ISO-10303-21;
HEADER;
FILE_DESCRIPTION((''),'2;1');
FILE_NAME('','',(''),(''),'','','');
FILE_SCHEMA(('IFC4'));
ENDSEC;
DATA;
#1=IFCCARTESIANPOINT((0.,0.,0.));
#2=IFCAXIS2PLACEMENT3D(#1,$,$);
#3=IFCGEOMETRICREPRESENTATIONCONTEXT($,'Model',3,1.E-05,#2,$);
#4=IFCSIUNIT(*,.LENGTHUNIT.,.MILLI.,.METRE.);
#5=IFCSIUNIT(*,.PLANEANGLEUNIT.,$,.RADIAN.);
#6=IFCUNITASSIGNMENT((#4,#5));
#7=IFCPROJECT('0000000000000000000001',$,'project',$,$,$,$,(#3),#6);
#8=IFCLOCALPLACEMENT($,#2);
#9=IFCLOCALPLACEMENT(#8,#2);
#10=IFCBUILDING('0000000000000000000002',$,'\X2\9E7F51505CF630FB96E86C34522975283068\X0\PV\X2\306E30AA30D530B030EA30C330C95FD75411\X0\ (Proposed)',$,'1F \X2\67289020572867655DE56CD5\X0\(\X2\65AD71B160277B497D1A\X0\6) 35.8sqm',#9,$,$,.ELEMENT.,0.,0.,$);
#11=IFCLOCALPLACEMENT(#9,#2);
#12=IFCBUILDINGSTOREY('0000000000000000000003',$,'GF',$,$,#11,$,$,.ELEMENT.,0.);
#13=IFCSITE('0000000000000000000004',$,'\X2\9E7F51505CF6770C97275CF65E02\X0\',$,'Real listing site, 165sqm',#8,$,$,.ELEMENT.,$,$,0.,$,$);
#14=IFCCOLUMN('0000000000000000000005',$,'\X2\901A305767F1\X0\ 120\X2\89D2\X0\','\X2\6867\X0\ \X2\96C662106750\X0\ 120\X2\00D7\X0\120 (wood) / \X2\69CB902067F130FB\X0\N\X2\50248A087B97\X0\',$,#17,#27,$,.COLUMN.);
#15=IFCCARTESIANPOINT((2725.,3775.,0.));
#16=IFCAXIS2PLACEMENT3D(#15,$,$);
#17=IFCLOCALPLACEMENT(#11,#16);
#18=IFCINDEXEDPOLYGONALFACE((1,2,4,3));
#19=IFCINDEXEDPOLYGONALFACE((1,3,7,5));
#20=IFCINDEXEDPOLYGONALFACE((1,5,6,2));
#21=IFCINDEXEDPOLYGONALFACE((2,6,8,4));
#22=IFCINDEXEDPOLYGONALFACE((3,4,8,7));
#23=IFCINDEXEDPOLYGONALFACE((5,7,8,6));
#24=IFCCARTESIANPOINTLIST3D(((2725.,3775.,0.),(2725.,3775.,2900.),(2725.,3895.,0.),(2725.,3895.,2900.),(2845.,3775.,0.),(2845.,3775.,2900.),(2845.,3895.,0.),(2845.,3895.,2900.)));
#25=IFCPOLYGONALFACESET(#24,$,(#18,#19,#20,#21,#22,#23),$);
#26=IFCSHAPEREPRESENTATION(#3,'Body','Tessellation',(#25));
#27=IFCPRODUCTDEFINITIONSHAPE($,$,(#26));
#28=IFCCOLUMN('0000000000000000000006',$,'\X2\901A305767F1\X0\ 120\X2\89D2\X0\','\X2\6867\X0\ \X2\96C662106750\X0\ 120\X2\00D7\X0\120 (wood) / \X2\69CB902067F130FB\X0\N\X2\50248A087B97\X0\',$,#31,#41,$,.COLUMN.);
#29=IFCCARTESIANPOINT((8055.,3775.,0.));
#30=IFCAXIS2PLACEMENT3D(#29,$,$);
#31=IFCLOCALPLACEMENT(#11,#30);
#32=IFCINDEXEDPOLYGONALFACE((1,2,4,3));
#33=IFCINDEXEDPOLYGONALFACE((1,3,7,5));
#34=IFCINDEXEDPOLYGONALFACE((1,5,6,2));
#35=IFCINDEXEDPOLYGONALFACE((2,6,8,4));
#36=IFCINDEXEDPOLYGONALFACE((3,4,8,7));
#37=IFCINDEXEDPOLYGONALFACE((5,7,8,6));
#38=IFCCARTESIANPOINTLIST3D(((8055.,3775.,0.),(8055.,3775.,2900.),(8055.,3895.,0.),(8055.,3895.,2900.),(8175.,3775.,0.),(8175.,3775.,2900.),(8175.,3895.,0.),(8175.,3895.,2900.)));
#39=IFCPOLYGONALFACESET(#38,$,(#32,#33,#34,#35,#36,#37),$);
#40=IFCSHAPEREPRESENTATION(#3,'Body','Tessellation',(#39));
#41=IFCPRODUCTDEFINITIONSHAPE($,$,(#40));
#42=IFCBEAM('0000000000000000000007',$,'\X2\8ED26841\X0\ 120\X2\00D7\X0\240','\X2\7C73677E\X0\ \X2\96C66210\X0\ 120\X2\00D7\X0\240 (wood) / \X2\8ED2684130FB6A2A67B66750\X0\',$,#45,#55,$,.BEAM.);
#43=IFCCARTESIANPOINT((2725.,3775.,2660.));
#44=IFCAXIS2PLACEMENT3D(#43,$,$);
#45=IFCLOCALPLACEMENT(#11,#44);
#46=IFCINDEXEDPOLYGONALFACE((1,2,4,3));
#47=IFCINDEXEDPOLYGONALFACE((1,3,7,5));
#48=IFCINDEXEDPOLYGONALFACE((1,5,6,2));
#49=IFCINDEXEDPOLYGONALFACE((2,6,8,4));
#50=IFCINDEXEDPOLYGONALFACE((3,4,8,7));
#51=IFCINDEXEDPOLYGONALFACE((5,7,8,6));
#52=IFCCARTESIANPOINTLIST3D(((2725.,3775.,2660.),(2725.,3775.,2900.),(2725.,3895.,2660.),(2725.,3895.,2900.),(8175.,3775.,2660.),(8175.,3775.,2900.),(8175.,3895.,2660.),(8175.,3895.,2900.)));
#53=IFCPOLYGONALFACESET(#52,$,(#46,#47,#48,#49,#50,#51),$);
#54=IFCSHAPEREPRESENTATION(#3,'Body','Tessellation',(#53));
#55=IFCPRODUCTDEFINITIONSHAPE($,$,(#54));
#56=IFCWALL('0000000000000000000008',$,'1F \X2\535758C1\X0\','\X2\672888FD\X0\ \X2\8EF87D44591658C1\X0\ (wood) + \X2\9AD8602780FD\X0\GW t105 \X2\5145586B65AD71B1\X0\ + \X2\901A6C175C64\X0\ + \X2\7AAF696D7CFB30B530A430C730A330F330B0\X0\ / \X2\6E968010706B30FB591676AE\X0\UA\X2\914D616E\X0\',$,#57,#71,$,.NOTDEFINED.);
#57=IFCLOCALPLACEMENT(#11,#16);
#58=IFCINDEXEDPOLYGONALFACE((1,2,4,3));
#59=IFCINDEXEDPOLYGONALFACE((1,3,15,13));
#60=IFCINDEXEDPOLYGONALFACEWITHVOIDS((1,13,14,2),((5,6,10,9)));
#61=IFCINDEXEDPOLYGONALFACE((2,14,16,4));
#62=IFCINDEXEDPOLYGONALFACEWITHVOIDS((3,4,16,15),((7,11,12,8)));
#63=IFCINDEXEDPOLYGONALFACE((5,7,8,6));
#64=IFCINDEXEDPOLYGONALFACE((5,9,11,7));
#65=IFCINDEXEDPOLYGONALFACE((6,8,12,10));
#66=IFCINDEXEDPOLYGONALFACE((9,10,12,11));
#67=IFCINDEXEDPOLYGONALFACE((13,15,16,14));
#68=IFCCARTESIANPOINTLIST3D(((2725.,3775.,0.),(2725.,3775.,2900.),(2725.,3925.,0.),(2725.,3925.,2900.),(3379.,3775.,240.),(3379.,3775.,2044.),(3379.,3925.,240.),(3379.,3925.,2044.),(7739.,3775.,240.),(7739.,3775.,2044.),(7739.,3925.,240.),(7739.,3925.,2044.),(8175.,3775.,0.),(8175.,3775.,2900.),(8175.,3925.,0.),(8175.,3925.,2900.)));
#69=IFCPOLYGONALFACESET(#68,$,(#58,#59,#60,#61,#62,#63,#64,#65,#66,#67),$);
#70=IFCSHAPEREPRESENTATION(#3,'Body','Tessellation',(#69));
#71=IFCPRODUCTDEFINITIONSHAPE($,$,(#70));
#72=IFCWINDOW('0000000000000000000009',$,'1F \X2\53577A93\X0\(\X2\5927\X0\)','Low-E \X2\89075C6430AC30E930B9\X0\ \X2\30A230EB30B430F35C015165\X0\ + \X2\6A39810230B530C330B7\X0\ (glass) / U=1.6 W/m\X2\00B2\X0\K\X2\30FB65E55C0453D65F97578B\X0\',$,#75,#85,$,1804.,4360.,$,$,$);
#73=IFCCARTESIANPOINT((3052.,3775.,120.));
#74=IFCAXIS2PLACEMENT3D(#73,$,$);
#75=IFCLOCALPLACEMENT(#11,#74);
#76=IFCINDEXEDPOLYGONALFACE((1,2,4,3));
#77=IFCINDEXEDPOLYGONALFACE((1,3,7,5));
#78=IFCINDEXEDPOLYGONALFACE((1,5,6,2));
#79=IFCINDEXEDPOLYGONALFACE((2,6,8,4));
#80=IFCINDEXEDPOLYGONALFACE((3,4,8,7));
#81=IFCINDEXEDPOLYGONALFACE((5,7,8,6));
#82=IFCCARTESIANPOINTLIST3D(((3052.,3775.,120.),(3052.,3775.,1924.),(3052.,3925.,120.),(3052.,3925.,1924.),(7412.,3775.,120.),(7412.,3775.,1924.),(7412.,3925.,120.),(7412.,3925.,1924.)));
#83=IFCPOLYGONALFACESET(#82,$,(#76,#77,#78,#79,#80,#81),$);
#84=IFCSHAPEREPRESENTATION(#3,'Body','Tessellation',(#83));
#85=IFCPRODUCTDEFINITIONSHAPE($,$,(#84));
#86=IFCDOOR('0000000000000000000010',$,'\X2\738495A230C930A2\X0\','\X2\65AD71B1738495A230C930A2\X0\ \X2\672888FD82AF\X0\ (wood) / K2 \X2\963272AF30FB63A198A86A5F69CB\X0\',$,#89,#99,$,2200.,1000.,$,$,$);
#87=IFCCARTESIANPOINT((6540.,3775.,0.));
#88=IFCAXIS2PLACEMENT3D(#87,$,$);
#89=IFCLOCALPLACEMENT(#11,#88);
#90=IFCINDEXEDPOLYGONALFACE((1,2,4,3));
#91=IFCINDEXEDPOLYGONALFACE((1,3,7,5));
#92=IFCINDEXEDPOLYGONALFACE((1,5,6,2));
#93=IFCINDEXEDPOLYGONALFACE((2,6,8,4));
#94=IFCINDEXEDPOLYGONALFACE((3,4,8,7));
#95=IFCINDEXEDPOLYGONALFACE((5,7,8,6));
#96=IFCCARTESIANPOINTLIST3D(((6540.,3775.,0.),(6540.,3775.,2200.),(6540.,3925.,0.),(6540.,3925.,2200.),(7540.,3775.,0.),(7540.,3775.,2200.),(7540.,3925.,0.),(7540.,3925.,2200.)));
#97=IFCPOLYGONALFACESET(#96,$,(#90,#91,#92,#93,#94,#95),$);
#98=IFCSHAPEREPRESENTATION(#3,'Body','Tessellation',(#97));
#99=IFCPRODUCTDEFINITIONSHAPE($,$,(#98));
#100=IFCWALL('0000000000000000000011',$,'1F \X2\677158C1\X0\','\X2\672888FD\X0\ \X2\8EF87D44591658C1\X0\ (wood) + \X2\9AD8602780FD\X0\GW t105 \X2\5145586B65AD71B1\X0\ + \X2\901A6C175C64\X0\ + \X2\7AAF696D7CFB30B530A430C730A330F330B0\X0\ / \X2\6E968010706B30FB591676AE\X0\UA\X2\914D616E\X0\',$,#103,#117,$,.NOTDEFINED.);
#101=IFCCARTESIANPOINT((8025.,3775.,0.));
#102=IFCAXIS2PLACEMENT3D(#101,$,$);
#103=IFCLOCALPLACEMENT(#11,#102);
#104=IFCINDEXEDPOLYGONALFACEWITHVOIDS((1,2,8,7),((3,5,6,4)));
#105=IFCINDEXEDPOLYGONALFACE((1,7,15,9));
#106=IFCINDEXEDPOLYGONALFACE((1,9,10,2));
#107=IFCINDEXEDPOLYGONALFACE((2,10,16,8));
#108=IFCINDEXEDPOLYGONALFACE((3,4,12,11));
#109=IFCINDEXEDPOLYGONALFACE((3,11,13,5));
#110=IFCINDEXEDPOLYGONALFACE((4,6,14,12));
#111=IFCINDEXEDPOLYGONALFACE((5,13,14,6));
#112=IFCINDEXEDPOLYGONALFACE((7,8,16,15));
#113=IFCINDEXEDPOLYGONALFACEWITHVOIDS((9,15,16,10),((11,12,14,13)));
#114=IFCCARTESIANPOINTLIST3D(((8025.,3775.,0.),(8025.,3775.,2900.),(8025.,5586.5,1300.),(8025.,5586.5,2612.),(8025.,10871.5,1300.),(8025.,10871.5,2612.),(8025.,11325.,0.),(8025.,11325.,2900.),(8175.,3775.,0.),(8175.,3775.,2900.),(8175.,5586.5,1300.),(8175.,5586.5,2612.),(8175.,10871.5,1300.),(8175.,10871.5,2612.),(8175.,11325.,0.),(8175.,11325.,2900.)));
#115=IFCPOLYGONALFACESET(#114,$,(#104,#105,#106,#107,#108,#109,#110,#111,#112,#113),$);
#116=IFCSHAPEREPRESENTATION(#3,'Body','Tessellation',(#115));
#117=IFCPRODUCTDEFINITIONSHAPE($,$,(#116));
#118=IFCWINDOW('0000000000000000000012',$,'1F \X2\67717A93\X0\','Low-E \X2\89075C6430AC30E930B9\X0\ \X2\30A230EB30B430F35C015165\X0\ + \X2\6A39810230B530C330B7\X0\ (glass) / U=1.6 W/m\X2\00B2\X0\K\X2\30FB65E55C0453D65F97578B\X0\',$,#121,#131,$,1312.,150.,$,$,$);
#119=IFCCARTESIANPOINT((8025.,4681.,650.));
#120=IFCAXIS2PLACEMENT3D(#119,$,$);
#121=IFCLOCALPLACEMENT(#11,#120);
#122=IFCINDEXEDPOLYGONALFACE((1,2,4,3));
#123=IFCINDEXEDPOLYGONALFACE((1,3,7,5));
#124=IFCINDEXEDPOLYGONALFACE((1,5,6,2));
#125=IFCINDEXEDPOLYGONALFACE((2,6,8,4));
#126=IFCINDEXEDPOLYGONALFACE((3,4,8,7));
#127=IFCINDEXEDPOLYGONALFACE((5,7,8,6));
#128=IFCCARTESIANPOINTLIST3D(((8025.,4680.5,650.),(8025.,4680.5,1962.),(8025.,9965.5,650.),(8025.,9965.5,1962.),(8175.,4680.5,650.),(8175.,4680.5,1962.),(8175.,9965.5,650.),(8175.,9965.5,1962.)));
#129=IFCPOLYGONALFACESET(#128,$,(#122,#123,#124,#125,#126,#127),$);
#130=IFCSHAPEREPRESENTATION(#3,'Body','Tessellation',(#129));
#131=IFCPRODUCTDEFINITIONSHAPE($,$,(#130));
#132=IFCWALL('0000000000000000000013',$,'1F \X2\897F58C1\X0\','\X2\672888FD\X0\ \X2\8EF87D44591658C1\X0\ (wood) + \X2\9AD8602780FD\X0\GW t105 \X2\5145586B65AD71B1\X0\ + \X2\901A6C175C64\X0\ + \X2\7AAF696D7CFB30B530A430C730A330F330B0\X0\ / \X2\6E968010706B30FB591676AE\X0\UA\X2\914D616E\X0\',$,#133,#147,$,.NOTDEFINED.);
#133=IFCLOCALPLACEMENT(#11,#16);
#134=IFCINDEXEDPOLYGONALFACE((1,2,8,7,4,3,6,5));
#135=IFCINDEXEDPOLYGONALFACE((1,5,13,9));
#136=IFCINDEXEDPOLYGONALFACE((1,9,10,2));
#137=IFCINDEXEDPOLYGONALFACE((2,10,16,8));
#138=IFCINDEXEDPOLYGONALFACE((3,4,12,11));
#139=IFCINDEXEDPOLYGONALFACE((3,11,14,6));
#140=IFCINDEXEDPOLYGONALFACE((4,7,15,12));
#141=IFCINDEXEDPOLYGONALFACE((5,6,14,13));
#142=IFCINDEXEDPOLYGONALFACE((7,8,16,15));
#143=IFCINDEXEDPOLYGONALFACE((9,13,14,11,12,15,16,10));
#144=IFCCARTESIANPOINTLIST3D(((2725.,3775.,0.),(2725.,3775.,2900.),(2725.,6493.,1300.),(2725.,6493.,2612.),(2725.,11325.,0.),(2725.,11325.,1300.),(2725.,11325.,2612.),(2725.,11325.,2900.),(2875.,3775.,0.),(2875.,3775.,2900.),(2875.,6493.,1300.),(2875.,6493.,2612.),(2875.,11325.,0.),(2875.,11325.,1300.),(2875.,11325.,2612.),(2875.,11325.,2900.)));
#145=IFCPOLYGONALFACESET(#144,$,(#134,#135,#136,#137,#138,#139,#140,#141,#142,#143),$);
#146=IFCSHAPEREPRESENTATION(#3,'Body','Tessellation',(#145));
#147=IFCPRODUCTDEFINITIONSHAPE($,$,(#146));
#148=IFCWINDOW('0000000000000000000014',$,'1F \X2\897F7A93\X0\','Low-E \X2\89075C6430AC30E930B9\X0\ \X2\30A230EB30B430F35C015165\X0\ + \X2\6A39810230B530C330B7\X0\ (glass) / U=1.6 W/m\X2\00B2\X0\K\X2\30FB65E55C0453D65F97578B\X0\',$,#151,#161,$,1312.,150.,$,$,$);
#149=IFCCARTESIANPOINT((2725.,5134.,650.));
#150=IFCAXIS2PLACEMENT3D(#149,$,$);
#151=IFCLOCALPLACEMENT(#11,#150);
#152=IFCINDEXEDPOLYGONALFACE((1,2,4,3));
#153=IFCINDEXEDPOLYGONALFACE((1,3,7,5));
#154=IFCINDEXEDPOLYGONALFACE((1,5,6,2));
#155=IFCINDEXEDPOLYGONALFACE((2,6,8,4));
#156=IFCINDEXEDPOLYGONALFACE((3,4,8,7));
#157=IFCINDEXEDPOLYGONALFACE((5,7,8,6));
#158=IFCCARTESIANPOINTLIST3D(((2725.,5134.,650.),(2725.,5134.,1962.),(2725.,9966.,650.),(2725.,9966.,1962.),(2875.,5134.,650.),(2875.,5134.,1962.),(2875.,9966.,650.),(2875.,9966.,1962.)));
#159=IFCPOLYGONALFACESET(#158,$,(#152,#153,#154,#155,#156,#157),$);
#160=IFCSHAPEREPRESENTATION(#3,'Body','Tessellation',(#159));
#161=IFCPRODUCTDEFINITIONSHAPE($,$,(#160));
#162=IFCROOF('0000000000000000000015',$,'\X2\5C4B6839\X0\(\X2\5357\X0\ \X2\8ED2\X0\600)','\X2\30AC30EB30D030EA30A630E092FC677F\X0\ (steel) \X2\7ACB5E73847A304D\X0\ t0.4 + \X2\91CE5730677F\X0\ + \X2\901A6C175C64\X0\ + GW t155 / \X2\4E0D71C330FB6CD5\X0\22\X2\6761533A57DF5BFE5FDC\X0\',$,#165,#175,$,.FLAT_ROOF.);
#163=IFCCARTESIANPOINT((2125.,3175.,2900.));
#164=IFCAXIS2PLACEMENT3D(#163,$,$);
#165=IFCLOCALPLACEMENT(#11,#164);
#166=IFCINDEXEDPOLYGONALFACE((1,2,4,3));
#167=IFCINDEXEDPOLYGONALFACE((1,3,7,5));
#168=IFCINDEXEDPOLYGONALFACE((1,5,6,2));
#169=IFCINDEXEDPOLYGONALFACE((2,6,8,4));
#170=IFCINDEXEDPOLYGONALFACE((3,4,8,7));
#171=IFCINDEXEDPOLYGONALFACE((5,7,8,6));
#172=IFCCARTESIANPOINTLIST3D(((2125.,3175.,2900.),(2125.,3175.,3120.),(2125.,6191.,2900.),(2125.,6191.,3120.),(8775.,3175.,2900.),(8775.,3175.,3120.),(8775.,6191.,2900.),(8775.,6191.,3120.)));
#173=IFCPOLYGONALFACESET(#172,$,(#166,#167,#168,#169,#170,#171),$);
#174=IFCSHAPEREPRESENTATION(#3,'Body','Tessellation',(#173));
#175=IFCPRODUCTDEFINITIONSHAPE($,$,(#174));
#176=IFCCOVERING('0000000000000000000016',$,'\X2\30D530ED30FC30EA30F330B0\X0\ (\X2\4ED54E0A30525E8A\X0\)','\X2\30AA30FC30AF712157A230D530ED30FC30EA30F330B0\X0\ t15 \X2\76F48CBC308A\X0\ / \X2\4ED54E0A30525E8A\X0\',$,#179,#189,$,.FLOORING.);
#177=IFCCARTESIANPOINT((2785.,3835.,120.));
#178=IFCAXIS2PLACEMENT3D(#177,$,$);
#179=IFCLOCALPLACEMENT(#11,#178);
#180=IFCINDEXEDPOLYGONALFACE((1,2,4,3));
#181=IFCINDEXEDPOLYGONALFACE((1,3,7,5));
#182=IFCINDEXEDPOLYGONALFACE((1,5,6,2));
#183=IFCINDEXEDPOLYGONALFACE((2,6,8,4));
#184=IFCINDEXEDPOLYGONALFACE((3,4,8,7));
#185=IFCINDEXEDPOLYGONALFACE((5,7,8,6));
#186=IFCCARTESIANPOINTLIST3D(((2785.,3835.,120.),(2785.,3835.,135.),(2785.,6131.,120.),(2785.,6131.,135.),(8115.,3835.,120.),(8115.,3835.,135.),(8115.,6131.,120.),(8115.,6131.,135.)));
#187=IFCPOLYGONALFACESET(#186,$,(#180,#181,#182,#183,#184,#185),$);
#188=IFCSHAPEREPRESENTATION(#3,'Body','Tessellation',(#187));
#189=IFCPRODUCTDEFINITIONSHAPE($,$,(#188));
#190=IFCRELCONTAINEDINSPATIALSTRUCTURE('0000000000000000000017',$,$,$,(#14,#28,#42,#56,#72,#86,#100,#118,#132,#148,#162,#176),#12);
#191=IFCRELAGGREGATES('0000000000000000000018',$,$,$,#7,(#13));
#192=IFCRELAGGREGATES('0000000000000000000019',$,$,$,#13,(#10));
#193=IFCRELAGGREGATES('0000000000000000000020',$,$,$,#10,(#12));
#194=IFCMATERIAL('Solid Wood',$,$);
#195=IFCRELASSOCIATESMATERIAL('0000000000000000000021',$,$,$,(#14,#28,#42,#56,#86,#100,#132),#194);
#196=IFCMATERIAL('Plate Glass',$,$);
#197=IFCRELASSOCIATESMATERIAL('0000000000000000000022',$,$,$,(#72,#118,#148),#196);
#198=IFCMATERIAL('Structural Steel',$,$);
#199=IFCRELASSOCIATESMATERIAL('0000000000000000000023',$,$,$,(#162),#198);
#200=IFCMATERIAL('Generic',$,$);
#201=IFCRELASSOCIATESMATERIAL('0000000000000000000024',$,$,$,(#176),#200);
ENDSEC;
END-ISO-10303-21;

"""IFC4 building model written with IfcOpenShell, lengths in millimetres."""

from ifc_helpers import new_model, si_unit, frame, frame_2d, origin, place, context, project, spatial, rectangle, extrude, material, element, fill, save


model = new_model("IFC4")

# Units and contexts
model_context = context("Model", 3, precision=1e-05, world=origin())
ifc_project = project(units=[si_unit("LENGTHUNIT", "METRE", prefix="MILLI"), si_unit("PLANEANGLEUNIT", "RADIAN")], contexts=[model_context])

# Site, building, storey
site_placement = place(None, origin())
site = spatial("IfcSite", under=ifc_project, at=site_placement, Name="鹿児島県霧島市", ObjectType="Real listing site, 165sqm", CompositionType="ELEMENT", RefElevation=0.0)
building_placement = place(site_placement, origin())
building = spatial("IfcBuilding", under=site, at=building_placement, Name="鹿児島・雨水利用とPVのオフグリッド志向 (Proposed)", ObjectType="1F 木造在来工法(断熱性等級6) 35.8sqm", CompositionType="ELEMENT", ElevationOfRefHeight=0.0, ElevationOfTerrain=0.0)
storey_placement = place(building_placement, origin())
storey = spatial("IfcBuildingStorey", under=building, at=storey_placement, Name="GF", CompositionType="ELEMENT", Elevation=0.0)

# Columns
ifc_material_1 = material(Name="Solid Wood")
column_1_placement = place(storey_placement, frame((2725.0, 3775.0, 0.0)))
element("IfcColumn", 1, at=column_1_placement, inside=storey, material=ifc_material_1, Name="通し柱 120角", Description="桧 集成材 120×120 (wood) / 構造柱・N値計算", PredefinedType="COLUMN", context=model_context, shape_type="SweptSolid", body=[
    extrude(rectangle(XDim=120.0, YDim=120.0, at=frame_2d((60.0, 60.0))), frame((2725.0, 3775.0, 0.0)), (0.0, 0.0, 1.0), 2900.0),
])
column_2_placement = place(storey_placement, frame((8055.0, 3775.0, 0.0)))
element("IfcColumn", 2, at=column_2_placement, inside=storey, material=ifc_material_1, Name="通し柱 120角", Description="桧 集成材 120×120 (wood) / 構造柱・N値計算", PredefinedType="COLUMN", context=model_context, shape_type="SweptSolid", body=[
    extrude(rectangle(XDim=120.0, YDim=120.0, at=frame_2d((60.0, 60.0))), frame((8055.0, 3775.0, 0.0)), (0.0, 0.0, 1.0), 2900.0),
])

# Beam
beam_1_placement = place(storey_placement, frame((2725.0, 3775.0, 2660.0)))
element("IfcBeam", 3, at=beam_1_placement, inside=storey, material=ifc_material_1, Name="軒桁 120×240", Description="米松 集成 120×240 (wood) / 軒桁・横架材", PredefinedType="BEAM", context=model_context, shape_type="SweptSolid", body=[
    extrude(rectangle(XDim=5450.0, YDim=120.0, at=frame_2d((2725.0, 60.0))), frame((2725.0, 3775.0, 2660.0)), (0.0, 0.0, 1.0), 240.0),
])

# Wall, openings, window, door
wall_1_placement = place(storey_placement, frame((2725.0, 3775.0, 0.0)))
wall_1 = element("IfcWall", 4, at=wall_1_placement, inside=storey, material=ifc_material_1, Name="1F 南壁", Description="木製 軸組外壁 (wood) + 高性能GW t105 充填断熱 + 通気層 + 窯業系サイディング / 準耐火・外皮UA配慮", PredefinedType="NOTDEFINED", context=model_context, shape_type="SweptSolid", body=[
    extrude(rectangle(XDim=5450.0, YDim=150.0, at=frame_2d((2725.0, 75.0))), frame((2725.0, 3775.0, 0.0)), (0.0, 0.0, 1.0), 2900.0),
])
opening_1_placement = place(storey_placement, frame((3052.0, 3775.0, 120.0)))
opening_1 = element("IfcOpeningElement", 5, at=opening_1_placement, cuts=wall_1, PredefinedType="NOTDEFINED", context=model_context, shape_type="SweptSolid", body=[
    extrude(rectangle(XDim=4360.0, YDim=150.0, at=frame_2d((2180.0, 75.0))), frame((3052.0, 3775.0, 120.0)), (0.0, 0.0, 1.0), 1804.0),
])
opening_2_placement = place(storey_placement, frame((6540.0, 3775.0, 0.0)))
opening_2 = element("IfcOpeningElement", 6, at=opening_2_placement, cuts=wall_1, PredefinedType="NOTDEFINED", context=model_context, shape_type="SweptSolid", body=[
    extrude(rectangle(XDim=1000.0, YDim=150.0, at=frame_2d((500.0, 75.0))), frame((6540.0, 3775.0, 0.0)), (0.0, 0.0, 1.0), 2200.0),
])
ifc_material_2 = material(Name="Plate Glass")
window_1_placement = place(storey_placement, frame((3052.0, 3775.0, 120.0)))
window_1 = element("IfcWindow", 7, at=window_1_placement, inside=storey, material=ifc_material_2, Name="1F 南窓(大)", Description="Low-E 複層ガラス アルゴン封入 + 樹脂サッシ (glass) / U=1.6 W/m²K・日射取得型", OverallHeight=1804.0, OverallWidth=4360.0, context=model_context, shape_type="SweptSolid", body=[
    extrude(rectangle(XDim=4360.0, YDim=150.0, at=frame_2d((2180.0, 75.0))), frame((3052.0, 3775.0, 120.0)), (0.0, 0.0, 1.0), 1804.0),
])
fill(opening_1, window_1)
door_placement = place(storey_placement, frame((6540.0, 3775.0, 0.0)))
door = element("IfcDoor", 8, at=door_placement, inside=storey, material=ifc_material_1, Name="玄関ドア", Description="断熱玄関ドア 木製芯 (wood) / K2 防犯・採風機構", OverallHeight=2200.0, OverallWidth=1000.0, context=model_context, shape_type="SweptSolid", body=[
    extrude(rectangle(XDim=1000.0, YDim=150.0, at=frame_2d((500.0, 75.0))), frame((6540.0, 3775.0, 0.0)), (0.0, 0.0, 1.0), 2200.0),
])
fill(opening_2, door)

# Walls, openings, windows
wall_2_placement = place(storey_placement, frame((8025.0, 3775.0, 0.0)))
wall_2 = element("IfcWall", 9, at=wall_2_placement, inside=storey, material=ifc_material_1, Name="1F 東壁", Description="木製 軸組外壁 (wood) + 高性能GW t105 充填断熱 + 通気層 + 窯業系サイディング / 準耐火・外皮UA配慮", PredefinedType="NOTDEFINED", context=model_context, shape_type="SweptSolid", body=[
    extrude(rectangle(XDim=150.0, YDim=7550.0, at=frame_2d((75.0, 3775.0))), frame((8025.0, 3775.0, 0.0)), (0.0, 0.0, 1.0), 2900.0),
])
opening_3_placement = place(storey_placement, frame((8025.0, 4681.0, 650.0)))
opening_3 = element("IfcOpeningElement", 10, at=opening_3_placement, cuts=wall_2, PredefinedType="NOTDEFINED", context=model_context, shape_type="SweptSolid", body=[
    extrude(rectangle(XDim=150.0, YDim=5285.0, at=frame_2d((75.0, 2642.0))), frame((8025.0, 4681.0, 650.0)), (0.0, 0.0, 1.0), 1312.0),
])
window_2_placement = place(storey_placement, frame((8025.0, 4681.0, 650.0)))
window_2 = element("IfcWindow", 11, at=window_2_placement, inside=storey, material=ifc_material_2, Name="1F 東窓", Description="Low-E 複層ガラス アルゴン封入 + 樹脂サッシ (glass) / U=1.6 W/m²K・日射取得型", OverallHeight=1312.0, OverallWidth=150.0, context=model_context, shape_type="SweptSolid", body=[
    extrude(rectangle(XDim=150.0, YDim=5285.0, at=frame_2d((75.0, 2642.0))), frame((8025.0, 4681.0, 650.0)), (0.0, 0.0, 1.0), 1312.0),
])
fill(opening_3, window_2)
wall_3_placement = place(storey_placement, frame((2725.0, 3775.0, 0.0)))
wall_3 = element("IfcWall", 12, at=wall_3_placement, inside=storey, material=ifc_material_1, Name="1F 西壁", Description="木製 軸組外壁 (wood) + 高性能GW t105 充填断熱 + 通気層 + 窯業系サイディング / 準耐火・外皮UA配慮", PredefinedType="NOTDEFINED", context=model_context, shape_type="SweptSolid", body=[
    extrude(rectangle(XDim=150.0, YDim=7550.0, at=frame_2d((75.0, 3775.0))), frame((2725.0, 3775.0, 0.0)), (0.0, 0.0, 1.0), 2900.0),
])
opening_4_placement = place(storey_placement, frame((2725.0, 5134.0, 650.0)))
opening_4 = element("IfcOpeningElement", 13, at=opening_4_placement, cuts=wall_3, PredefinedType="NOTDEFINED", context=model_context, shape_type="SweptSolid", body=[
    extrude(rectangle(XDim=150.0, YDim=4832.0, at=frame_2d((75.0, 2416.0))), frame((2725.0, 5134.0, 650.0)), (0.0, 0.0, 1.0), 1312.0),
])
window_3_placement = place(storey_placement, frame((2725.0, 5134.0, 650.0)))
window_3 = element("IfcWindow", 14, at=window_3_placement, inside=storey, material=ifc_material_2, Name="1F 西窓", Description="Low-E 複層ガラス アルゴン封入 + 樹脂サッシ (glass) / U=1.6 W/m²K・日射取得型", OverallHeight=1312.0, OverallWidth=150.0, context=model_context, shape_type="SweptSolid", body=[
    extrude(rectangle(XDim=150.0, YDim=4832.0, at=frame_2d((75.0, 2416.0))), frame((2725.0, 5134.0, 650.0)), (0.0, 0.0, 1.0), 1312.0),
])
fill(opening_4, window_3)

# Roof
ifc_material_3 = material(Name="Structural Steel")
roof_placement = place(storey_placement, frame((2125.0, 3175.0, 2900.0)))
element("IfcRoof", 15, at=roof_placement, inside=storey, material=ifc_material_3, Name="屋根(南 軒600)", Description="ガルバリウム鋼板 (steel) 立平葺き t0.4 + 野地板 + 通気層 + GW t155 / 不燃・法22条区域対応", PredefinedType="FLAT_ROOF", context=model_context, shape_type="SweptSolid", body=[
    extrude(rectangle(XDim=6650.0, YDim=3016.0, at=frame_2d((3325.0, 1508.0))), frame((2125.0, 3175.0, 2900.0)), (0.0, 0.0, 1.0), 220.0),
])

# Covering
ifc_material_4 = material(Name="Generic")
covering_1_placement = place(storey_placement, frame((2785.0, 3835.0, 120.0)))
element("IfcCovering", 16, at=covering_1_placement, inside=storey, material=ifc_material_4, Name="フローリング (仕上げ床)", Description="オーク無垢フローリング t15 直貼り / 仕上げ床", PredefinedType="FLOORING", context=model_context, shape_type="SweptSolid", body=[
    extrude(rectangle(XDim=5330.0, YDim=2296.0, at=frame_2d((2665.0, 1148.0))), frame((2785.0, 3835.0, 120.0)), (0.0, 0.0, 1.0), 15.0),
])

save(model, "model.ifc")
